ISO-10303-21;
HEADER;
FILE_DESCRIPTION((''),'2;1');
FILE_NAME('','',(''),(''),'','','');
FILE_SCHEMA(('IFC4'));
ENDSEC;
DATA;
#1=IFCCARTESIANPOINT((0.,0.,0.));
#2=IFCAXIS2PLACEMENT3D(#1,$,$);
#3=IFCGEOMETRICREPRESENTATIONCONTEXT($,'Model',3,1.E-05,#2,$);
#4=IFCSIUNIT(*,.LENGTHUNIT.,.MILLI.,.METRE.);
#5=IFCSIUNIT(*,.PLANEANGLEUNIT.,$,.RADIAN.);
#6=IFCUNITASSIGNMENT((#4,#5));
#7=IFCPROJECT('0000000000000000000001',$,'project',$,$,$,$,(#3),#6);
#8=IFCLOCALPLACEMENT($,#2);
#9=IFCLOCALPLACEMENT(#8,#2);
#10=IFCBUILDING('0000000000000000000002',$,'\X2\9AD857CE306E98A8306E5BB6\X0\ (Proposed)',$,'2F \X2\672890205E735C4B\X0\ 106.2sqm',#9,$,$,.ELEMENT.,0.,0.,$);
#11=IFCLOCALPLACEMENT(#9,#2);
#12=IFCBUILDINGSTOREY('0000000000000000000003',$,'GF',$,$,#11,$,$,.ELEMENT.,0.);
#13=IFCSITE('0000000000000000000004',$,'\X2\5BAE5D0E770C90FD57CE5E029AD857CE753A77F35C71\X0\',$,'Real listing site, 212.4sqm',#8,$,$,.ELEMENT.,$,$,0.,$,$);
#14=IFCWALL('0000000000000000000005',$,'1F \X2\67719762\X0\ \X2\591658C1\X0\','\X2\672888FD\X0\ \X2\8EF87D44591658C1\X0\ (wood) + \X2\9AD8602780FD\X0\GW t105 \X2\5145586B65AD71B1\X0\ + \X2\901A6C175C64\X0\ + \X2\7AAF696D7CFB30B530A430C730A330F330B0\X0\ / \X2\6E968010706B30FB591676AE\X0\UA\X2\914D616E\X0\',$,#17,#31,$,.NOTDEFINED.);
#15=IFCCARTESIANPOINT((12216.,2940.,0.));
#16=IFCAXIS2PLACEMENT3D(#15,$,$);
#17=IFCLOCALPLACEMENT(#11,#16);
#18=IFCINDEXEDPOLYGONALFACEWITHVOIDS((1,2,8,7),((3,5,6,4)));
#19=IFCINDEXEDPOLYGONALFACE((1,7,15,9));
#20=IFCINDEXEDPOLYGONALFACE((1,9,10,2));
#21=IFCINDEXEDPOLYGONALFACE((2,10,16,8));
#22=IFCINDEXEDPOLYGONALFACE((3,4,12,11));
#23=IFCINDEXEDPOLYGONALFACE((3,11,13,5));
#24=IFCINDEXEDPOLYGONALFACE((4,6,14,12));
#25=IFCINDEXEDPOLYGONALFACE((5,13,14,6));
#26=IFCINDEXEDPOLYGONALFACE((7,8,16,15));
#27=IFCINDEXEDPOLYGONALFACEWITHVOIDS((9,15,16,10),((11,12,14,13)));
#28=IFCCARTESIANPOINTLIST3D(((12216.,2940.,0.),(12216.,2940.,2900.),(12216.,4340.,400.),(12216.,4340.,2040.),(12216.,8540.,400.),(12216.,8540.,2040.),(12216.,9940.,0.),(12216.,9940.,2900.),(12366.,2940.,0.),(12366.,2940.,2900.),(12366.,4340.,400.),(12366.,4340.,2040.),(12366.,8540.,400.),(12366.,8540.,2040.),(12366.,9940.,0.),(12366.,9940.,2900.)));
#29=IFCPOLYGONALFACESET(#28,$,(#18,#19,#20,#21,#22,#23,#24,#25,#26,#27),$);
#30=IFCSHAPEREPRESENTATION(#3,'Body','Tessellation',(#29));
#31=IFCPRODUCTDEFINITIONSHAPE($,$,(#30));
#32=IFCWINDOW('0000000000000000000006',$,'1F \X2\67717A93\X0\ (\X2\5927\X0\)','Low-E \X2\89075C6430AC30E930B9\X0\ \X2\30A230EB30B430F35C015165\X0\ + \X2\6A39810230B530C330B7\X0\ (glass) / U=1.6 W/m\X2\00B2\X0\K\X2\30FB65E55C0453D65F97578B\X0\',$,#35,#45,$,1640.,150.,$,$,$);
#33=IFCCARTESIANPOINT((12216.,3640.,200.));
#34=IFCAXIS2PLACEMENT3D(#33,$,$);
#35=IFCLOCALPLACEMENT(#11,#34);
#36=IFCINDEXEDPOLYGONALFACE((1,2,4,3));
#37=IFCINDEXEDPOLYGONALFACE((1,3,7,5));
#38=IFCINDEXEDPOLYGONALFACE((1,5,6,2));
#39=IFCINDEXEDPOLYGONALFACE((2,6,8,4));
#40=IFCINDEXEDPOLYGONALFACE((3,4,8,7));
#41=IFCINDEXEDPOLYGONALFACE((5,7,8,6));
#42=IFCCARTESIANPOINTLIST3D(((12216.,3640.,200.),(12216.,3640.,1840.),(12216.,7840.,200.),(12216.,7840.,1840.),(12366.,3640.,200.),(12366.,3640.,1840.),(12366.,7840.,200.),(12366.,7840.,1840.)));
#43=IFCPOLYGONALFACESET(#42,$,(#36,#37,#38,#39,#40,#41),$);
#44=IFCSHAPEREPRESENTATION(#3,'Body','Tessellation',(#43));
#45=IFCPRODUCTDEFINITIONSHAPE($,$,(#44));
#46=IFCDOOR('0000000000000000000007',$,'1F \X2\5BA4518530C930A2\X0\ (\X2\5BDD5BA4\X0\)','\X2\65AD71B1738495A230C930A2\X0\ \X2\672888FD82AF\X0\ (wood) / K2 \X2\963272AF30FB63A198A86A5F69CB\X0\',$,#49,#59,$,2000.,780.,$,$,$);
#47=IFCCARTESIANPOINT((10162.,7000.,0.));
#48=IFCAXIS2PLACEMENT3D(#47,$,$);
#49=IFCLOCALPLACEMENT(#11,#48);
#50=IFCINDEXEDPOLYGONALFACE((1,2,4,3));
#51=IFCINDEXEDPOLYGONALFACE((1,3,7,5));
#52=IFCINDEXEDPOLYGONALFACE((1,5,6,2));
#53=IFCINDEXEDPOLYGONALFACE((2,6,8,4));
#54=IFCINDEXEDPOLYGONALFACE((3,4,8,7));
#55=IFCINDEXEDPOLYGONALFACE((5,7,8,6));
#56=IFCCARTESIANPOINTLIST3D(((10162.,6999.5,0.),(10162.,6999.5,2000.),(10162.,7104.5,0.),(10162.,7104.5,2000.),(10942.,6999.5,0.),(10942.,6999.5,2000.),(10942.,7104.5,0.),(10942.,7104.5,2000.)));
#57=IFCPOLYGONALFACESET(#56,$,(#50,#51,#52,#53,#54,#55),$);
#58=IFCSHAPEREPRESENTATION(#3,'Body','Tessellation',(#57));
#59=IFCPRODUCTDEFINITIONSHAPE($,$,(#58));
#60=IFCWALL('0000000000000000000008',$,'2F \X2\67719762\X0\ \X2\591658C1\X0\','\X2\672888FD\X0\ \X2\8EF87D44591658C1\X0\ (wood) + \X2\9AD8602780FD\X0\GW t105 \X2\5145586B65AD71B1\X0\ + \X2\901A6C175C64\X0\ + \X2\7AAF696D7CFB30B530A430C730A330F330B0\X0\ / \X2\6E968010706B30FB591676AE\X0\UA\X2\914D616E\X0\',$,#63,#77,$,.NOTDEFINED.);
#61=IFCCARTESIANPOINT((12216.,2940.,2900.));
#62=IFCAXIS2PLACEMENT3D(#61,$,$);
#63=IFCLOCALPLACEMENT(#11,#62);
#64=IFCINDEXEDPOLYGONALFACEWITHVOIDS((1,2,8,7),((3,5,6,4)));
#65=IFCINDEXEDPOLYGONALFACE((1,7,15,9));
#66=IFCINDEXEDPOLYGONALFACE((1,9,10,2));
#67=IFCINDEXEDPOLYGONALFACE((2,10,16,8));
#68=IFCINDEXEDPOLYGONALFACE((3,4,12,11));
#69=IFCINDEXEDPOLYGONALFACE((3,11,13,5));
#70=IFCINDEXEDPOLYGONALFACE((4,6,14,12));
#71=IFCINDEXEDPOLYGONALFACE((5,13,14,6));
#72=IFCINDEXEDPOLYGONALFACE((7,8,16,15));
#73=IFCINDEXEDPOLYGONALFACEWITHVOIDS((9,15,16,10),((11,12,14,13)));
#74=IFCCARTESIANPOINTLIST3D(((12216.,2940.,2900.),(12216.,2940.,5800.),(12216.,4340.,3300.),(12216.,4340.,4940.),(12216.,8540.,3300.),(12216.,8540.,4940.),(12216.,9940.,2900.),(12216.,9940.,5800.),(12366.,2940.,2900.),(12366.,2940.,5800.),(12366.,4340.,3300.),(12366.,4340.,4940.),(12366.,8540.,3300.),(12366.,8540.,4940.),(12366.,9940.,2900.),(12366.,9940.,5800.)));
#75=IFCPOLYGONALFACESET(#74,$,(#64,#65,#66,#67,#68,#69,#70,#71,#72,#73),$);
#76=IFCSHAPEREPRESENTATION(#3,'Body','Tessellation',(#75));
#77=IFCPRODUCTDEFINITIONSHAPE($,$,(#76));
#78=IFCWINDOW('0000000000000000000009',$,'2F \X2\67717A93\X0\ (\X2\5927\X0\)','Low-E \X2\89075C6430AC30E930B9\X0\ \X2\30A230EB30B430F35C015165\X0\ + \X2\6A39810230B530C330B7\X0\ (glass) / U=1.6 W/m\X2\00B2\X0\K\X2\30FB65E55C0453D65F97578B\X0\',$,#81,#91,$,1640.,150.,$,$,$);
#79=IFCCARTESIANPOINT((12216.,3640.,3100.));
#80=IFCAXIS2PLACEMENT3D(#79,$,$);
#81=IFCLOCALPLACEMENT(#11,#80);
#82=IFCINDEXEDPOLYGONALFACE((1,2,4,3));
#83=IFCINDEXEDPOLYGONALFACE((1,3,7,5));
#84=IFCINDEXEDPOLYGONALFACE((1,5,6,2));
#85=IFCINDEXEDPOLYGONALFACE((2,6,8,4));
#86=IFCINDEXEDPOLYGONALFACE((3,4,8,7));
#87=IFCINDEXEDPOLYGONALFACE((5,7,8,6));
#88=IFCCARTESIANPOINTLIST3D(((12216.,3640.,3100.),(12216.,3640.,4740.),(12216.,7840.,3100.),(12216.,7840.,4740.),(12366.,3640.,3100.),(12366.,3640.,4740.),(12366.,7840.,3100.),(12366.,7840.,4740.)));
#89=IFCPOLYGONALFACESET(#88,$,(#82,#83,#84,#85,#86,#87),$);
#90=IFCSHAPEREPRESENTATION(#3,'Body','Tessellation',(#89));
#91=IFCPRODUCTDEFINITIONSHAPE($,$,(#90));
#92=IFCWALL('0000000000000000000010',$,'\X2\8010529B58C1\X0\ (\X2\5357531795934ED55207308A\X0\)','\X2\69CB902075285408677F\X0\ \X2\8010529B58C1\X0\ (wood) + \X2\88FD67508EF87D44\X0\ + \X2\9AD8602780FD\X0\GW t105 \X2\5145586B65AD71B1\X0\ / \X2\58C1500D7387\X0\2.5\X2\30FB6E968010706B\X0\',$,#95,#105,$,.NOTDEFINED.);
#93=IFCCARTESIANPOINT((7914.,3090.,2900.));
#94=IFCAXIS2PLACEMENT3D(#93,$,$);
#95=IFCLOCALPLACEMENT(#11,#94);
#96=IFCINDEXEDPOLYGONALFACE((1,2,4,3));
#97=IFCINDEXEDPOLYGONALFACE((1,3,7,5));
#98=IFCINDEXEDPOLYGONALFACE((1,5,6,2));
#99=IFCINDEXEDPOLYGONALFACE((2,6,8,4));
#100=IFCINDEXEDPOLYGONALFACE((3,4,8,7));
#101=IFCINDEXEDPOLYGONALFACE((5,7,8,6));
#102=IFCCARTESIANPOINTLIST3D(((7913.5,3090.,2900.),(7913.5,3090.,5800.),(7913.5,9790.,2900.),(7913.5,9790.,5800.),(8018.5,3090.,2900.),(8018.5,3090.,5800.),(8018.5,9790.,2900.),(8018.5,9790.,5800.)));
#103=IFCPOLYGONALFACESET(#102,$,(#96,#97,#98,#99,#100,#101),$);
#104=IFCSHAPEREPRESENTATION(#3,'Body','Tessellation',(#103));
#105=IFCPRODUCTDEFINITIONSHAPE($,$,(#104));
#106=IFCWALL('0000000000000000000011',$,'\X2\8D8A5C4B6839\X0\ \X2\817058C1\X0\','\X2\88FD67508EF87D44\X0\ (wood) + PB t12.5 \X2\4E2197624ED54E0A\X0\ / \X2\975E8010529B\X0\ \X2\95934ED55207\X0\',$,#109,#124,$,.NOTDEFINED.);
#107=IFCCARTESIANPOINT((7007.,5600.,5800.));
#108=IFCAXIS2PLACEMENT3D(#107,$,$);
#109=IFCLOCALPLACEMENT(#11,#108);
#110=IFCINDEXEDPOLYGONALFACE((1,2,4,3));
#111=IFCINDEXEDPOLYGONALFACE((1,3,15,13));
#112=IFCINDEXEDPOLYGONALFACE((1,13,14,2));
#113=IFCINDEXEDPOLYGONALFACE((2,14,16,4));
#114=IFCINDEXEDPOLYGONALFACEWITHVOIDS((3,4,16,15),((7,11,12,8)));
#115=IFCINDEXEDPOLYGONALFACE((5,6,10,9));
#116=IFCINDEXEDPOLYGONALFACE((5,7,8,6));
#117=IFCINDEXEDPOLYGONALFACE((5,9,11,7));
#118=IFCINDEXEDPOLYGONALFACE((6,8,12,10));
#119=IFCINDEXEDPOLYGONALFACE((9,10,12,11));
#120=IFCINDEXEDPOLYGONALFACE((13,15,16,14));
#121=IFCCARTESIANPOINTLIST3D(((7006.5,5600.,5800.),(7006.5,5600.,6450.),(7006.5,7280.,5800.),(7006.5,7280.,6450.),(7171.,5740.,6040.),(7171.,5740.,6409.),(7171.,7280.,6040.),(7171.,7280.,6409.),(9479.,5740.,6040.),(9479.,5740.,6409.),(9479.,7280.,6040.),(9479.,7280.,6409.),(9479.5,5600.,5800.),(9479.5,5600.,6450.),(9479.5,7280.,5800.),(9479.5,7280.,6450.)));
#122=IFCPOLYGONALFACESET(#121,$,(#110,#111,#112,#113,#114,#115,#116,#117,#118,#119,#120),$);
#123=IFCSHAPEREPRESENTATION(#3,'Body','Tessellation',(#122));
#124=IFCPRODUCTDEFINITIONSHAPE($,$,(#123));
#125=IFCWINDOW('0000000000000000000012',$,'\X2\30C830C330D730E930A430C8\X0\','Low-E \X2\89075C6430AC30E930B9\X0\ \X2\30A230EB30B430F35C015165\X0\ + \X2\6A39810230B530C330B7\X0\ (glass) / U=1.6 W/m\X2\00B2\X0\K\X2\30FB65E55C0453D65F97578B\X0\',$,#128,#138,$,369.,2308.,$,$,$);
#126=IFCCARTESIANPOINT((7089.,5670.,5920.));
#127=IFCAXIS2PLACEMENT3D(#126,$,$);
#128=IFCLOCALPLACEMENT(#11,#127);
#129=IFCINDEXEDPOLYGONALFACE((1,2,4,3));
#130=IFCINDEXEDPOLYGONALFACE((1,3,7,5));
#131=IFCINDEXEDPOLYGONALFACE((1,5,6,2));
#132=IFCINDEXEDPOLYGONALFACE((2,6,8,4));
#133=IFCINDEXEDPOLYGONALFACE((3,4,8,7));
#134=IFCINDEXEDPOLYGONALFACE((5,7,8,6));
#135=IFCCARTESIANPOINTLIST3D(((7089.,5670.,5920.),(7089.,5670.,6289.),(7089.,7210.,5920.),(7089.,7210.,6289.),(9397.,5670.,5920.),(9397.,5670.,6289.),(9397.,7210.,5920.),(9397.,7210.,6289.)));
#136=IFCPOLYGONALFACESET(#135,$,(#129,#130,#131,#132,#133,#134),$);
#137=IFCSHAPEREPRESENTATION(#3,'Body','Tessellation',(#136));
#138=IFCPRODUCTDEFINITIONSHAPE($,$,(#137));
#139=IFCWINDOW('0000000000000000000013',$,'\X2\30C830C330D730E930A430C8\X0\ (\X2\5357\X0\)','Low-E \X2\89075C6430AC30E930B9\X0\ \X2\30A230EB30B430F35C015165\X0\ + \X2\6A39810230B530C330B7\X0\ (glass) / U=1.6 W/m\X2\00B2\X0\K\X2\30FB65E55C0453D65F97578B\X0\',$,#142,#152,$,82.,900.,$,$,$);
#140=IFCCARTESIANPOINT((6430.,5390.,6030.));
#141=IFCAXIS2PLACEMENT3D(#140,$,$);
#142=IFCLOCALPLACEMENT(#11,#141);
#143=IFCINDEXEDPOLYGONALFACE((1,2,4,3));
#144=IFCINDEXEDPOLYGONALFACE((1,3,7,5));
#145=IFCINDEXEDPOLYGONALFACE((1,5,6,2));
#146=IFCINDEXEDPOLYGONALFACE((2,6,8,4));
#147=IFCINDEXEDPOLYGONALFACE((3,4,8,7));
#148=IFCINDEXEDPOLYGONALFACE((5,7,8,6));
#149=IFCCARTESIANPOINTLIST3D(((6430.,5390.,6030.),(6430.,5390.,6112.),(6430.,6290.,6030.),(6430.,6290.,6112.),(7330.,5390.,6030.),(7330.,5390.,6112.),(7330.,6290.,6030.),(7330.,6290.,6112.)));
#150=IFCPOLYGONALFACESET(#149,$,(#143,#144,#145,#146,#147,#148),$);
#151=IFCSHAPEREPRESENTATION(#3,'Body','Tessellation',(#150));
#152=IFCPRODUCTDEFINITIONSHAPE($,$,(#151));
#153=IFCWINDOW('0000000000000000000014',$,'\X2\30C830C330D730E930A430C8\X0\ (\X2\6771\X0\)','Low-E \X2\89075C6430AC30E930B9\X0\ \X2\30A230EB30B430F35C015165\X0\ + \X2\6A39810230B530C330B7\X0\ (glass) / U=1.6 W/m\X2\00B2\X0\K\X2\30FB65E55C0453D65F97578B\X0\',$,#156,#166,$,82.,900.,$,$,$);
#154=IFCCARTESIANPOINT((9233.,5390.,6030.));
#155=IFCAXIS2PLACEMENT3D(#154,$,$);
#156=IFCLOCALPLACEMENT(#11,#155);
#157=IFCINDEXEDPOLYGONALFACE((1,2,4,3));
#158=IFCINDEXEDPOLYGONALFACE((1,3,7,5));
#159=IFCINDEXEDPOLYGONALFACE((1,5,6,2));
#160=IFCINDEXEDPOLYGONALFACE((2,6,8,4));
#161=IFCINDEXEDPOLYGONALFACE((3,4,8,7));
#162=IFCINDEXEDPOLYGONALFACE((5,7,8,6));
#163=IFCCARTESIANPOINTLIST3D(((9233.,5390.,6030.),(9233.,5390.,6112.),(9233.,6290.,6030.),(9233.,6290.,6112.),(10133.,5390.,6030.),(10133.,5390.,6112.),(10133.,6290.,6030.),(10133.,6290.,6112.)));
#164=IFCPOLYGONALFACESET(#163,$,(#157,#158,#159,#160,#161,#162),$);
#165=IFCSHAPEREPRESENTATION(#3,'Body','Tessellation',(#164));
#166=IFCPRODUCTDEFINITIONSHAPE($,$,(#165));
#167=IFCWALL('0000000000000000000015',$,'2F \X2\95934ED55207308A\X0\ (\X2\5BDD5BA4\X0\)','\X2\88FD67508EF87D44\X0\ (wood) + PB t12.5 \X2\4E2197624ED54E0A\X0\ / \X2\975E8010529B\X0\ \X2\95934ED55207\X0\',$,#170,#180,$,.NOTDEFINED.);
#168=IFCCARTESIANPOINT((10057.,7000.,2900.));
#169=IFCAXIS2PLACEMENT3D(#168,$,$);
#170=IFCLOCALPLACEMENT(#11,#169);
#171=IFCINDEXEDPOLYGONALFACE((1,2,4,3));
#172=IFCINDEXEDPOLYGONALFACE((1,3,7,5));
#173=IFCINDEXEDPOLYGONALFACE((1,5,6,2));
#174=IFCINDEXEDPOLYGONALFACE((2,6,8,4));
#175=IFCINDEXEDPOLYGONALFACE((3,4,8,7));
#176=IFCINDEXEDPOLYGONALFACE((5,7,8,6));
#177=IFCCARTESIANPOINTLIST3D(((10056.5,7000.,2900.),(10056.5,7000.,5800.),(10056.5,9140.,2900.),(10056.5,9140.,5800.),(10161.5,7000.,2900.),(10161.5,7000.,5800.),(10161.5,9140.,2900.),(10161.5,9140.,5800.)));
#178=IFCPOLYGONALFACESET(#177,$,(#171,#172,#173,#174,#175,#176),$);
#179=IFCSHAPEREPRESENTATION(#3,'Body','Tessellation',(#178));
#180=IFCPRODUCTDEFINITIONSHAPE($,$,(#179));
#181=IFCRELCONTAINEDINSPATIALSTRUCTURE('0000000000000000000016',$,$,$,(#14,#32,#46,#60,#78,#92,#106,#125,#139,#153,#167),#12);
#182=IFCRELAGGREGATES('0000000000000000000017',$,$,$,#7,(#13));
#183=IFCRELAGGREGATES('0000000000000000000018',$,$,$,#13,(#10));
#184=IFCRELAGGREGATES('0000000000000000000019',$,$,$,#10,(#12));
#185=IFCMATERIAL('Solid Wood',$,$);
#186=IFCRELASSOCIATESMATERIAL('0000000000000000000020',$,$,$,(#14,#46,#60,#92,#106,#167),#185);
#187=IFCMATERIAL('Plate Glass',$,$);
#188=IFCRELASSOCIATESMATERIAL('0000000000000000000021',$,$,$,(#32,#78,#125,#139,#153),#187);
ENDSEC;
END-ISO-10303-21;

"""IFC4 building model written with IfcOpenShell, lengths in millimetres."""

from ifc_helpers import new_model, si_unit, frame, frame_2d, origin, place, context, project, spatial, rectangle, extrude, material, element, fill, save


model = new_model("IFC4")

# Units and contexts
model_context = context("Model", 3, precision=1e-05, world=origin())
ifc_project = project(units=[si_unit("LENGTHUNIT", "METRE", prefix="MILLI"), si_unit("PLANEANGLEUNIT", "RADIAN")], contexts=[model_context])

# Site, building, storey
site_placement = place(None, origin())
site = spatial("IfcSite", under=ifc_project, at=site_placement, Name="宮崎県都城市高城町石山", ObjectType="Real listing site, 212.4sqm", CompositionType="ELEMENT", RefElevation=0.0)
building_placement = place(site_placement, origin())
building = spatial("IfcBuilding", under=site, at=building_placement, Name="高城の風の家 (Proposed)", ObjectType="2F 木造平屋 106.2sqm", CompositionType="ELEMENT", ElevationOfRefHeight=0.0, ElevationOfTerrain=0.0)
storey_placement = place(building_placement, origin())
storey = spatial("IfcBuildingStorey", under=building, at=storey_placement, Name="GF", CompositionType="ELEMENT", Elevation=0.0)

# Wall, opening, window
ifc_material_1 = material(Name="Solid Wood")
wall_1_placement = place(storey_placement, frame((12216.0, 2940.0, 0.0)))
wall_1 = element("IfcWall", 1, at=wall_1_placement, inside=storey, material=ifc_material_1, Name="1F 東面 外壁", Description="木製 軸組外壁 (wood) + 高性能GW t105 充填断熱 + 通気層 + 窯業系サイディング / 準耐火・外皮UA配慮", PredefinedType="NOTDEFINED", context=model_context, shape_type="SweptSolid", body=[
    extrude(rectangle(XDim=150.0, YDim=7000.0, at=frame_2d((75.0, 3500.0))), frame((12216.0, 2940.0, 0.0)), (0.0, 0.0, 1.0), 2900.0),
])
opening_1_placement = place(storey_placement, frame((12216.0, 3640.0, 200.0)))
opening_1 = element("IfcOpeningElement", 2, at=opening_1_placement, cuts=wall_1, PredefinedType="NOTDEFINED", context=model_context, shape_type="SweptSolid", body=[
    extrude(rectangle(XDim=150.0, YDim=4200.0, at=frame_2d((75.0, 2100.0))), frame((12216.0, 3640.0, 200.0)), (0.0, 0.0, 1.0), 1640.0),
])
ifc_material_2 = material(Name="Plate Glass")
window_1_placement = place(storey_placement, frame((12216.0, 3640.0, 200.0)))
window_1 = element("IfcWindow", 3, at=window_1_placement, inside=storey, material=ifc_material_2, Name="1F 東窓 (大)", Description="Low-E 複層ガラス アルゴン封入 + 樹脂サッシ (glass) / U=1.6 W/m²K・日射取得型", OverallHeight=1640.0, OverallWidth=150.0, context=model_context, shape_type="SweptSolid", body=[
    extrude(rectangle(XDim=150.0, YDim=4200.0, at=frame_2d((75.0, 2100.0))), frame((12216.0, 3640.0, 200.0)), (0.0, 0.0, 1.0), 1640.0),
])
fill(opening_1, window_1)

# Door
door_1_placement = place(storey_placement, frame((10162.0, 7000.0, 0.0)))
element("IfcDoor", 4, at=door_1_placement, inside=storey, material=ifc_material_1, Name="1F 室内ドア (寝室)", Description="断熱玄関ドア 木製芯 (wood) / K2 防犯・採風機構", OverallHeight=2000.0, OverallWidth=780.0, context=model_context, shape_type="SweptSolid", body=[
    extrude(rectangle(XDim=780.0, YDim=105.0, at=frame_2d((390.0, 52.0))), frame((10162.0, 7000.0, 0.0)), (0.0, 0.0, 1.0), 2000.0),
])

# Wall, opening, window
wall_2_placement = place(storey_placement, frame((12216.0, 2940.0, 2900.0)))
wall_2 = element("IfcWall", 5, at=wall_2_placement, inside=storey, material=ifc_material_1, Name="2F 東面 外壁", Description="木製 軸組外壁 (wood) + 高性能GW t105 充填断熱 + 通気層 + 窯業系サイディング / 準耐火・外皮UA配慮", PredefinedType="NOTDEFINED", context=model_context, shape_type="SweptSolid", body=[
    extrude(rectangle(XDim=150.0, YDim=7000.0, at=frame_2d((75.0, 3500.0))), frame((12216.0, 2940.0, 2900.0)), (0.0, 0.0, 1.0), 2900.0),
])
opening_2_placement = place(storey_placement, frame((12216.0, 3640.0, 3100.0)))
opening_2 = element("IfcOpeningElement", 6, at=opening_2_placement, cuts=wall_2, PredefinedType="NOTDEFINED", context=model_context, shape_type="SweptSolid", body=[
    extrude(rectangle(XDim=150.0, YDim=4200.0, at=frame_2d((75.0, 2100.0))), frame((12216.0, 3640.0, 3100.0)), (0.0, 0.0, 1.0), 1640.0),
])
window_2_placement = place(storey_placement, frame((12216.0, 3640.0, 3100.0)))
window_2 = element("IfcWindow", 7, at=window_2_placement, inside=storey, material=ifc_material_2, Name="2F 東窓 (大)", Description="Low-E 複層ガラス アルゴン封入 + 樹脂サッシ (glass) / U=1.6 W/m²K・日射取得型", OverallHeight=1640.0, OverallWidth=150.0, context=model_context, shape_type="SweptSolid", body=[
    extrude(rectangle(XDim=150.0, YDim=4200.0, at=frame_2d((75.0, 2100.0))), frame((12216.0, 3640.0, 3100.0)), (0.0, 0.0, 1.0), 1640.0),
])
fill(opening_2, window_2)

# Wall
wall_3_placement = place(storey_placement, frame((7914.0, 3090.0, 2900.0)))
element("IfcWall", 8, at=wall_3_placement, inside=storey, material=ifc_material_1, Name="耐力壁 (南北間仕切り)", Description="構造用合板 耐力壁 (wood) + 製材軸組 + 高性能GW t105 充填断熱 / 壁倍率2.5・準耐火", PredefinedType="NOTDEFINED", context=model_context, shape_type="SweptSolid", body=[
    extrude(rectangle(XDim=105.0, YDim=6700.0, at=frame_2d((52.0, 3350.0))), frame((7914.0, 3090.0, 2900.0)), (0.0, 0.0, 1.0), 2900.0),
])

# Wall, openings, windows
wall_4_placement = place(storey_placement, frame((7007.0, 5600.0, 5800.0)))
wall_4 = element("IfcWall", 9, at=wall_4_placement, inside=storey, material=ifc_material_1, Name="越屋根 腰壁", Description="製材軸組 (wood) + PB t12.5 両面仕上 / 非耐力 間仕切", PredefinedType="NOTDEFINED", context=model_context, shape_type="SweptSolid", body=[
    extrude(rectangle(XDim=2473.0, YDim=1680.0, at=frame_2d((1236.0, 840.0))), frame((7007.0, 5600.0, 5800.0)), (0.0, 0.0, 1.0), 650.0),
])
opening_3_placement = place(storey_placement, frame((7089.0, 5670.0, 5920.0)))
opening_3 = element("IfcOpeningElement", 10, at=opening_3_placement, cuts=wall_4, PredefinedType="NOTDEFINED", context=model_context, shape_type="SweptSolid", body=[
    extrude(rectangle(XDim=2308.0, YDim=1540.0, at=frame_2d((1154.0, 770.0))), frame((7089.0, 5670.0, 5920.0)), (0.0, 0.0, 1.0), 369.0),
])
opening_4_placement = place(storey_placement, frame((6430.0, 5390.0, 6030.0)))
opening_4 = element("IfcOpeningElement", 11, at=opening_4_placement, cuts=wall_4, PredefinedType="NOTDEFINED", context=model_context, shape_type="SweptSolid", body=[
    extrude(rectangle(XDim=900.0, YDim=900.0, at=frame_2d((450.0, 450.0))), frame((6430.0, 5390.0, 6030.0)), (0.0, 0.0, 1.0), 82.0),
])
opening_5_placement = place(storey_placement, frame((9233.0, 5390.0, 6030.0)))
opening_5 = element("IfcOpeningElement", 12, at=opening_5_placement, cuts=wall_4, PredefinedType="NOTDEFINED", context=model_context, shape_type="SweptSolid", body=[
    extrude(rectangle(XDim=900.0, YDim=900.0, at=frame_2d((450.0, 450.0))), frame((9233.0, 5390.0, 6030.0)), (0.0, 0.0, 1.0), 82.0),
])
window_3_placement = place(storey_placement, frame((7089.0, 5670.0, 5920.0)))
window_3 = element("IfcWindow", 13, at=window_3_placement, inside=storey, material=ifc_material_2, Name="トップライト", Description="Low-E 複層ガラス アルゴン封入 + 樹脂サッシ (glass) / U=1.6 W/m²K・日射取得型", OverallHeight=369.0, OverallWidth=2308.0, context=model_context, shape_type="SweptSolid", body=[
    extrude(rectangle(XDim=2308.0, YDim=1540.0, at=frame_2d((1154.0, 770.0))), frame((7089.0, 5670.0, 5920.0)), (0.0, 0.0, 1.0), 369.0),
])
fill(opening_3, window_3)
window_4_placement = place(storey_placement, frame((6430.0, 5390.0, 6030.0)))
window_4 = element("IfcWindow", 14, at=window_4_placement, inside=storey, material=ifc_material_2, Name="トップライト (南)", Description="Low-E 複層ガラス アルゴン封入 + 樹脂サッシ (glass) / U=1.6 W/m²K・日射取得型", OverallHeight=82.0, OverallWidth=900.0, context=model_context, shape_type="SweptSolid", body=[
    extrude(rectangle(XDim=900.0, YDim=900.0, at=frame_2d((450.0, 450.0))), frame((6430.0, 5390.0, 6030.0)), (0.0, 0.0, 1.0), 82.0),
])
fill(opening_4, window_4)
window_5_placement = place(storey_placement, frame((9233.0, 5390.0, 6030.0)))
window_5 = element("IfcWindow", 15, at=window_5_placement, inside=storey, material=ifc_material_2, Name="トップライト (東)", Description="Low-E 複層ガラス アルゴン封入 + 樹脂サッシ (glass) / U=1.6 W/m²K・日射取得型", OverallHeight=82.0, OverallWidth=900.0, context=model_context, shape_type="SweptSolid", body=[
    extrude(rectangle(XDim=900.0, YDim=900.0, at=frame_2d((450.0, 450.0))), frame((9233.0, 5390.0, 6030.0)), (0.0, 0.0, 1.0), 82.0),
])
fill(opening_5, window_5)

# Wall
wall_5_placement = place(storey_placement, frame((10057.0, 7000.0, 2900.0)))
element("IfcWall", 16, at=wall_5_placement, inside=storey, material=ifc_material_1, Name="2F 間仕切り (寝室)", Description="製材軸組 (wood) + PB t12.5 両面仕上 / 非耐力 間仕切", PredefinedType="NOTDEFINED", context=model_context, shape_type="SweptSolid", body=[
    extrude(rectangle(XDim=105.0, YDim=2140.0, at=frame_2d((52.0, 1070.0))), frame((10057.0, 7000.0, 2900.0)), (0.0, 0.0, 1.0), 2900.0),
])

save(model, "model.ifc")
